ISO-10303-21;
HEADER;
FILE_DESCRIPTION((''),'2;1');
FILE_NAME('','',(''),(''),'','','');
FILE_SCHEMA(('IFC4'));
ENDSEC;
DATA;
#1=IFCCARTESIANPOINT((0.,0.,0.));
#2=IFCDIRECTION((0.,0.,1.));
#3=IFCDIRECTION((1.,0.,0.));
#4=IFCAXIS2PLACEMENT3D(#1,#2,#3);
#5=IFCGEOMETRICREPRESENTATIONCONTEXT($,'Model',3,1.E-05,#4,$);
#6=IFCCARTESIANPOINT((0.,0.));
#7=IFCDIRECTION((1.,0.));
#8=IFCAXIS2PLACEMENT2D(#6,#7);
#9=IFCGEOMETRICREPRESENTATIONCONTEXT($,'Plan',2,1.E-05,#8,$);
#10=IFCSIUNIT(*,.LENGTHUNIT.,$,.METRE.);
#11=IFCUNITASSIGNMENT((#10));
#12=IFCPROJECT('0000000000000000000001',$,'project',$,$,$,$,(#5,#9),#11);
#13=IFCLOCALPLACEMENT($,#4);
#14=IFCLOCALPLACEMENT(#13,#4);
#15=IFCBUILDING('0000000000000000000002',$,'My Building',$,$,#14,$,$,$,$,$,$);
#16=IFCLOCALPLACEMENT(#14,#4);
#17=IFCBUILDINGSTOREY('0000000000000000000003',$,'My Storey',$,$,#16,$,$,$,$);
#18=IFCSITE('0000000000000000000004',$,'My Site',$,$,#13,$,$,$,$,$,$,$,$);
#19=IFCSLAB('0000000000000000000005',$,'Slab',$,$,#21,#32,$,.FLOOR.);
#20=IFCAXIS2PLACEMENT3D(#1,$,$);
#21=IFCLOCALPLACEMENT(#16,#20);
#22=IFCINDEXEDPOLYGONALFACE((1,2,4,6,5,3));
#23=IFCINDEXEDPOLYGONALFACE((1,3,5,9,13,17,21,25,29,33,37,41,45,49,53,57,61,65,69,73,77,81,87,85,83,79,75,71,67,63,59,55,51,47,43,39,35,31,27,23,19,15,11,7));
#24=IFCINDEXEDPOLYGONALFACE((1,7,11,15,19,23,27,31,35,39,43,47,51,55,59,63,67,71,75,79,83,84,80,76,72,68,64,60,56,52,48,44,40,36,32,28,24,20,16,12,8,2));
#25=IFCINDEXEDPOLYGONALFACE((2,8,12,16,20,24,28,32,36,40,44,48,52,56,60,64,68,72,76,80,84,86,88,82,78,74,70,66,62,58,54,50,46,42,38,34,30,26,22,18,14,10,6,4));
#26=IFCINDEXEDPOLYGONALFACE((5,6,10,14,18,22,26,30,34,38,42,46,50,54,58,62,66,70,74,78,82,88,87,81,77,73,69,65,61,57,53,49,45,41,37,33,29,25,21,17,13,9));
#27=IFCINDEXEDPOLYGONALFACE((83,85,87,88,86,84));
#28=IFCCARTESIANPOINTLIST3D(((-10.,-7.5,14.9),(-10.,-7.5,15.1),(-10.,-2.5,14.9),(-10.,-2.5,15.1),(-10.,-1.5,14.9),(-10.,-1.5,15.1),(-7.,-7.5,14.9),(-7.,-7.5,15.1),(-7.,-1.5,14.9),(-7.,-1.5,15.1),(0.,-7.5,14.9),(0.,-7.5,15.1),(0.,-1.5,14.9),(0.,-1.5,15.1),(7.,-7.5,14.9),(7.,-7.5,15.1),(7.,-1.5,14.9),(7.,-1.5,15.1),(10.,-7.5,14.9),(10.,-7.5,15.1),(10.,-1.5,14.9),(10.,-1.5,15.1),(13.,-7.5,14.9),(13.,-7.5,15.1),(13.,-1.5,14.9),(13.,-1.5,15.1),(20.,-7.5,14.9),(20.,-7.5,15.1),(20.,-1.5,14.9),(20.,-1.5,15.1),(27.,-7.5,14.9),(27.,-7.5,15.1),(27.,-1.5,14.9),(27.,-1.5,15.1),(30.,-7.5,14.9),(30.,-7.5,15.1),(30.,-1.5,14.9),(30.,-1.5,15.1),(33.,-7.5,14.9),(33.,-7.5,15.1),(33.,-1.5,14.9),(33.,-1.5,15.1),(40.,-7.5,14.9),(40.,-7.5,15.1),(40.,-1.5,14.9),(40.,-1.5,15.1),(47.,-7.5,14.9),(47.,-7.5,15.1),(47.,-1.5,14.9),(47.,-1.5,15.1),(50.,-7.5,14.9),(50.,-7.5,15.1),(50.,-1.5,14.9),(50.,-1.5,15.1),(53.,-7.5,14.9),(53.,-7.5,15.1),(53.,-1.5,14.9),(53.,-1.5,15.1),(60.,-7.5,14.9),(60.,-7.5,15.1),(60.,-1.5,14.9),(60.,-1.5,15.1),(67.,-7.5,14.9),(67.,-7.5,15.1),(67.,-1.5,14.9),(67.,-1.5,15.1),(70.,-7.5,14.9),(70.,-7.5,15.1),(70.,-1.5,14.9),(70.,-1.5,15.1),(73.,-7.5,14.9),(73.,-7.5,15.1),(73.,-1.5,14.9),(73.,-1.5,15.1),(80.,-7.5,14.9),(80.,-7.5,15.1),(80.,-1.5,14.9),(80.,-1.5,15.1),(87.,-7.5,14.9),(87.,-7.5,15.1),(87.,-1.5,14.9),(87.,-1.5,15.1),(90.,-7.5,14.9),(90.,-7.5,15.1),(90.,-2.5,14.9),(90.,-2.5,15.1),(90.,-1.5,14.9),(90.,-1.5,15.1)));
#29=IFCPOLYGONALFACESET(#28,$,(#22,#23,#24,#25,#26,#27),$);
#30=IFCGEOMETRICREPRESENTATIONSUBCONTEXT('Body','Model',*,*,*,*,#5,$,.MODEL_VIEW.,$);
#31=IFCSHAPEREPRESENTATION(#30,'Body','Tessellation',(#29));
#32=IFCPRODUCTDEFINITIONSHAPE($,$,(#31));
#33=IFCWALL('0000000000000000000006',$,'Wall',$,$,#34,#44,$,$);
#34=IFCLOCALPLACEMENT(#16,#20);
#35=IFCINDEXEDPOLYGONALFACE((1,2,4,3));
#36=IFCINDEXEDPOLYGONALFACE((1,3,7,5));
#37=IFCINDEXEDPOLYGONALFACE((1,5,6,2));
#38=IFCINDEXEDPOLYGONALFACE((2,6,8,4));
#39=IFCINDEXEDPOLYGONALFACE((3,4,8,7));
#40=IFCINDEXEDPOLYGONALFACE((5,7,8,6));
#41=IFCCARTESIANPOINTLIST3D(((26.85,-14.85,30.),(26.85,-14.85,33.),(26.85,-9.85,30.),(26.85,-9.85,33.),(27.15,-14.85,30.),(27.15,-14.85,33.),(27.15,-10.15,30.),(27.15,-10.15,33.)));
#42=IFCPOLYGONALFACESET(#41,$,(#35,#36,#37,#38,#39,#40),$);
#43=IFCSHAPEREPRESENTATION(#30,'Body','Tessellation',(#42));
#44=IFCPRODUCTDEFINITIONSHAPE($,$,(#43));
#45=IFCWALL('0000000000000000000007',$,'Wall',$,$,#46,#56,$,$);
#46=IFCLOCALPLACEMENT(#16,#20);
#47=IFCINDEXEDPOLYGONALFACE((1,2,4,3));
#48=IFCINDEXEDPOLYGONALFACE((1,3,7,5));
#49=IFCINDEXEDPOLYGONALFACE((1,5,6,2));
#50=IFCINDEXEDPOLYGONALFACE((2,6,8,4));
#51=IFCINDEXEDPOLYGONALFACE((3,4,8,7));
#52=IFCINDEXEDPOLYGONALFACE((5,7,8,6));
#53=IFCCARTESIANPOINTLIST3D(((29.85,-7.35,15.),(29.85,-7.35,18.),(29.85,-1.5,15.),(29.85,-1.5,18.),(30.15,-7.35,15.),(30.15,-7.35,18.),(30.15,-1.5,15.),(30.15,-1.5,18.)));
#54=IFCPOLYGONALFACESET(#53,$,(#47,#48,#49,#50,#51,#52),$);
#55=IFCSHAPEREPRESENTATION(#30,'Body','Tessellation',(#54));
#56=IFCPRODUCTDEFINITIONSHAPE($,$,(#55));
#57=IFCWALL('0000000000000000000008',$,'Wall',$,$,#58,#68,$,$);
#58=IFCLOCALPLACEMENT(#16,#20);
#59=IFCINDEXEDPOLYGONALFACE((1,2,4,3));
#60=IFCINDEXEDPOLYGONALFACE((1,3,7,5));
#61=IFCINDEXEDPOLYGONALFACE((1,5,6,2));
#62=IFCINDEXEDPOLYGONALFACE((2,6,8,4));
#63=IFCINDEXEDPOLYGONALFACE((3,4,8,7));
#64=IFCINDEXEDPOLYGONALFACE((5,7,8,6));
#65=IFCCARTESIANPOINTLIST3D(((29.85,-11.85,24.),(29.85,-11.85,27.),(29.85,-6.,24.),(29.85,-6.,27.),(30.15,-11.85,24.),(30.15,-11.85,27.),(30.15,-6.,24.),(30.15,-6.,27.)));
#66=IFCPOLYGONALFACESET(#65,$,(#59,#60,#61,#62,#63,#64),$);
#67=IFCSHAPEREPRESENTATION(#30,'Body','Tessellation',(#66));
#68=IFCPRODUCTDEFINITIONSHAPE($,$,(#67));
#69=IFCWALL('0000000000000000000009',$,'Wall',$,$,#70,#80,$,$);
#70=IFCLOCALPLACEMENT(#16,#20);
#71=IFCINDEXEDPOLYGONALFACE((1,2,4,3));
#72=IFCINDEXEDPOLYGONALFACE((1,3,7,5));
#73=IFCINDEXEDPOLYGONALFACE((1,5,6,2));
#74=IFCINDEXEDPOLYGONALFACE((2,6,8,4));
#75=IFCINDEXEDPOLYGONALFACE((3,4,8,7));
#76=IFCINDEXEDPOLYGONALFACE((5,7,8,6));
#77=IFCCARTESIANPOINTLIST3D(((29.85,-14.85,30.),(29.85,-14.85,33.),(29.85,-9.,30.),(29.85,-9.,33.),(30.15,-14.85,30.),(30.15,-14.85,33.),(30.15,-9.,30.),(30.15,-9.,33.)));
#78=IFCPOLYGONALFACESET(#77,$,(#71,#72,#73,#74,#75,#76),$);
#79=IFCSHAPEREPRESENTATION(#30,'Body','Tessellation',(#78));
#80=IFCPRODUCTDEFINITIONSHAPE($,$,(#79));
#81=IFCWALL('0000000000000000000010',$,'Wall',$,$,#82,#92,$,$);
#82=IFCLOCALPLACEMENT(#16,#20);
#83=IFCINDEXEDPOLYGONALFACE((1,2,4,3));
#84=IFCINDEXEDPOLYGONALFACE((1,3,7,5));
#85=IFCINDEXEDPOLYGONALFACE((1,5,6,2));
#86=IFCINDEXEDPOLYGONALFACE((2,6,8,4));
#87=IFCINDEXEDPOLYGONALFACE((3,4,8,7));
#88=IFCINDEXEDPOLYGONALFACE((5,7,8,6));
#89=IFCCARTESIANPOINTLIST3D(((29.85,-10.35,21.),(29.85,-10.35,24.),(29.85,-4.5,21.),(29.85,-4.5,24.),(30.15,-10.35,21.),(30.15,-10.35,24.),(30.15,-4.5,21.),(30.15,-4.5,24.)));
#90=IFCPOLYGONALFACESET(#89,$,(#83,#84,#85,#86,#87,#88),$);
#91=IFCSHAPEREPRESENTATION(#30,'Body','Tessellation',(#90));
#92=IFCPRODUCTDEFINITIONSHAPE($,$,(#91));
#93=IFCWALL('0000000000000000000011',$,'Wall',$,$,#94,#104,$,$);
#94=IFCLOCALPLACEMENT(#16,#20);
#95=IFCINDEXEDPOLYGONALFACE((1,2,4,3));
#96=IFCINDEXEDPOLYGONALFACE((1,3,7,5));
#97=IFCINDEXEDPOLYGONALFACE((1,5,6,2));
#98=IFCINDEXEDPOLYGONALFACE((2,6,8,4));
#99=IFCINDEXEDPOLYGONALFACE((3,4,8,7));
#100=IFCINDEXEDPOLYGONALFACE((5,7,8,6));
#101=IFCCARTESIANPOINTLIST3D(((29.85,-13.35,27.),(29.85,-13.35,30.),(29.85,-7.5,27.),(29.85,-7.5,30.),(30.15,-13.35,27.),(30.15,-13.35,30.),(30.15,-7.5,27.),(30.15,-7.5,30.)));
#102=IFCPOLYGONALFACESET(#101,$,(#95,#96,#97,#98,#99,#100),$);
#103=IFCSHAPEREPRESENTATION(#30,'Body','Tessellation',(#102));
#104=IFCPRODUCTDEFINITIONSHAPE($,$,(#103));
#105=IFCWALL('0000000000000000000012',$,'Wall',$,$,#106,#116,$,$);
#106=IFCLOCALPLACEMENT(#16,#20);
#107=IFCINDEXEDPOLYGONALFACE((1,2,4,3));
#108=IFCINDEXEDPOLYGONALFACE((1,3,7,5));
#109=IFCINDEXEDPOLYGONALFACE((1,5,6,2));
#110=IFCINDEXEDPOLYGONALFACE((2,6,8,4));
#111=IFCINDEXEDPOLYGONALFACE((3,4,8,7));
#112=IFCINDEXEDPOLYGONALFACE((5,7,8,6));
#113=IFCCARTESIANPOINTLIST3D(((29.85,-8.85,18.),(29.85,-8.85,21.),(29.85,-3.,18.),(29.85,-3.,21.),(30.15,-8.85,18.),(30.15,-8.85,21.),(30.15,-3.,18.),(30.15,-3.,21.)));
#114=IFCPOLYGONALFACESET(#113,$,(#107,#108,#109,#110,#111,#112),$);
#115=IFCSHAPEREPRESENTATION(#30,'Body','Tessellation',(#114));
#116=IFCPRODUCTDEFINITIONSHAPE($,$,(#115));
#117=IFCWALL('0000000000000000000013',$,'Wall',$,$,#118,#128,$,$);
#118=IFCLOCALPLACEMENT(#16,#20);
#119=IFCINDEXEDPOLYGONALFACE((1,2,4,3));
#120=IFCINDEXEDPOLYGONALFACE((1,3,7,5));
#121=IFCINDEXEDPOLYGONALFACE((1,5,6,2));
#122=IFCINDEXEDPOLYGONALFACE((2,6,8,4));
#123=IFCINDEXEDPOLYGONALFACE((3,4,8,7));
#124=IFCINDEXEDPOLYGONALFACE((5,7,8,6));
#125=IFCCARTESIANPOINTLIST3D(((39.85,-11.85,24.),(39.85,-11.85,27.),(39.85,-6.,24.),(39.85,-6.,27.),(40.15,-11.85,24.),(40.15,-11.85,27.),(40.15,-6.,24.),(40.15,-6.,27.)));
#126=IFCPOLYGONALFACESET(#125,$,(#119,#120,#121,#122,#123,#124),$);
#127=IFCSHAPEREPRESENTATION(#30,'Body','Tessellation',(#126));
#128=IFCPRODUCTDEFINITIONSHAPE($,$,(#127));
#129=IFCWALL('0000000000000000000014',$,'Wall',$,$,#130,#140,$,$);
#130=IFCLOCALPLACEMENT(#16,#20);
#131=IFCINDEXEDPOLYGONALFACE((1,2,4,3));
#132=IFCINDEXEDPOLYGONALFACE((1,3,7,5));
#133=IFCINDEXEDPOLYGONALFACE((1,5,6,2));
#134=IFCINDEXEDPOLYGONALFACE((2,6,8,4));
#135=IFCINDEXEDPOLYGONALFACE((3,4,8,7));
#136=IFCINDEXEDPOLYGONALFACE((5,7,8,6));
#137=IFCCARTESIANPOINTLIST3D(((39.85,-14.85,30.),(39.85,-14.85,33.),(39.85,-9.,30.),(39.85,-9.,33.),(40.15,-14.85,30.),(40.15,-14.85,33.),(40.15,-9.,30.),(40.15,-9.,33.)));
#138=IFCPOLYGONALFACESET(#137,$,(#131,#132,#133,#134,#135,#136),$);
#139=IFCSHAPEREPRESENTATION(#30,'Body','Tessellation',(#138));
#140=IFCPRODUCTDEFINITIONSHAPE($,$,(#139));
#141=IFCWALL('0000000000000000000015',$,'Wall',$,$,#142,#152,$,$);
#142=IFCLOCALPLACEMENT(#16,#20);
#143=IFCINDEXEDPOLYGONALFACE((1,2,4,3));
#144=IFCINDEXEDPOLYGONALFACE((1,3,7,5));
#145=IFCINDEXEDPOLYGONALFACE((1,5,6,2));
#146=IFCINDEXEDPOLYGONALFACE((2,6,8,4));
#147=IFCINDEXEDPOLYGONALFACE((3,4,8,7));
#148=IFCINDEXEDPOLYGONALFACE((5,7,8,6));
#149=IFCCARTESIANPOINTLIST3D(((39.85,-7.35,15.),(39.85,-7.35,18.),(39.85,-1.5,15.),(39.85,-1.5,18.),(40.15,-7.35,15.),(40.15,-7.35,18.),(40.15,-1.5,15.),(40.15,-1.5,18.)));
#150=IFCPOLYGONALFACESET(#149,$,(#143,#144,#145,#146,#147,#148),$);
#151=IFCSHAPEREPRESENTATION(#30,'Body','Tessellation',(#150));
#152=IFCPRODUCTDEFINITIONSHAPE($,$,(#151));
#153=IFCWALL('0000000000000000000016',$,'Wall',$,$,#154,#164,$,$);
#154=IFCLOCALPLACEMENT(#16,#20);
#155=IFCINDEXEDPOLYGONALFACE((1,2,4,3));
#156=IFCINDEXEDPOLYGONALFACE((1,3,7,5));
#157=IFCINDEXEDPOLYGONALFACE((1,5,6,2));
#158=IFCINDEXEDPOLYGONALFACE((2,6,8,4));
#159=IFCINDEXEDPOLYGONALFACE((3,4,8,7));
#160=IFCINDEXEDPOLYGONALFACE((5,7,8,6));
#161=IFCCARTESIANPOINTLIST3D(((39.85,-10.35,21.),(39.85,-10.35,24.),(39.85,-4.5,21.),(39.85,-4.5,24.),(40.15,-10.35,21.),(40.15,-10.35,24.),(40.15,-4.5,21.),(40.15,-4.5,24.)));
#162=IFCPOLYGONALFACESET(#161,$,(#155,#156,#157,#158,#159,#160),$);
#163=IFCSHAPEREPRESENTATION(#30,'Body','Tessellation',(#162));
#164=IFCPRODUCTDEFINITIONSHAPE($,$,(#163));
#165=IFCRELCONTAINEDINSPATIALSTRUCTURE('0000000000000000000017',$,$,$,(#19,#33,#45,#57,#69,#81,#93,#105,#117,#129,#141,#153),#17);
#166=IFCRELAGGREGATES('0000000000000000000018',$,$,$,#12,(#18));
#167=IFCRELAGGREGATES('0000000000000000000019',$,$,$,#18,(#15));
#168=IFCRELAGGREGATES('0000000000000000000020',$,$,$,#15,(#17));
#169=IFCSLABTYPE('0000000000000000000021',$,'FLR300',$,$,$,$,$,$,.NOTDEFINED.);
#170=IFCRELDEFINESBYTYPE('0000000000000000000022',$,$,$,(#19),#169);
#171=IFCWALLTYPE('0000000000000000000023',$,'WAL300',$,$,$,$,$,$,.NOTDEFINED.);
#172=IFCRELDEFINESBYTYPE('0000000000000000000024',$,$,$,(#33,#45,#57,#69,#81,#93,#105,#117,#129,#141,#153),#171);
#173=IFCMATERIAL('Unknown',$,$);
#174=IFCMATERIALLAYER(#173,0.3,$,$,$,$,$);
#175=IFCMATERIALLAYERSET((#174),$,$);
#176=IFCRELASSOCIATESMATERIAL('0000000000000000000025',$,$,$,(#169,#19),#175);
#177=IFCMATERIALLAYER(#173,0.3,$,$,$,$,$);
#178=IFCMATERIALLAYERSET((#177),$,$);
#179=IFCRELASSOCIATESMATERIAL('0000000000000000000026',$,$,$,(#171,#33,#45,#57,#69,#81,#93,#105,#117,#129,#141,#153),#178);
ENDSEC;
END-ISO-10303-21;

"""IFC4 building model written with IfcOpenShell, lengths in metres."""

from ifc_helpers import new_model, si_unit, frame, origin, origin_with_axes, origin_2d_with_axis, place, context, subcontext, project, spatial, polyline, line, indexed_curve, outline, extrude, material, layer, layer_set, layer_usage, type_object, element, save


model = new_model("IFC4")

# Units and contexts
model_context = context("Model", 3, precision=1e-05, world=origin_with_axes())
plan_context = context("Plan", 2, precision=1e-05, world=origin_2d_with_axis())
body_context = subcontext(model_context, "Body", "Model", "MODEL_VIEW")
ifc_project = project(units=[si_unit("LENGTHUNIT", "METRE")], contexts=[model_context, plan_context])

# Site, building, storey
site_placement = place(None, origin_with_axes())
site = spatial("IfcSite", under=ifc_project, at=site_placement, Name="My Site")
building_placement = place(site_placement, origin_with_axes())
building = spatial("IfcBuilding", under=site, at=building_placement, Name="My Building")
storey_placement = place(building_placement, origin_with_axes())
storey = spatial("IfcBuildingStorey", under=building, at=storey_placement, Name="My Storey")

# Slab
ifc_material = material(Name="Unknown")
ifc_layer_1 = layer(ifc_material, 0.3)
ifc_layer_set_1 = layer_set([ifc_layer_1])
ifc_layer_usage_1 = layer_usage(ifc_layer_set_1, "AXIS3", "POSITIVE", 0.0)
slab_type = type_object("IfcSlabType", Name="FLR300", PredefinedType="NOTDEFINED", material=ifc_layer_set_1)
slab_placement = place(storey_placement, frame((40.0, -4.4091, 14.9), z_axis=(0.0, 0.0, 1.0), x_axis=(1.0, 0.0, 0.0)))
element("IfcSlab", 1, at=slab_placement, inside=storey, type_object=slab_type, material=ifc_layer_usage_1, Name="Slab", PredefinedType="FLOOR", context=body_context, shape_type="SweptSolid", body=[
    extrude(outline(polyline([(-47.0, 2.9091), (-50.0, 2.9091), (-50.0, 1.9091), (-50.0, -3.0909), (-47.0, -3.0909), (-40.0, -3.0909), (-33.0, -3.0909), (-30.0, -3.0909), (-27.0, -3.0909), (-20.0, -3.0909), (-13.0, -3.0909), (-10.0, -3.0909), (-7.0, -3.0909), (0.0, -3.0909), (7.0, -3.0909), (10.0, -3.0909), (13.0, -3.0909), (20.0, -3.0909), (27.0, -3.0909), (30.0, -3.0909), (33.0, -3.0909), (40.0, -3.0909), (47.0, -3.0909), (50.0, -3.0909), (50.0, 1.9091), (50.0, 2.9091), (47.0, 2.9091), (40.0, 2.9091), (33.0, 2.9091), (30.0, 2.9091), (27.0, 2.9091), (20.0, 2.9091), (13.0, 2.9091), (10.0, 2.9091), (7.0, 2.9091), (0.0, 2.9091), (-7.0, 2.9091), (-10.0, 2.9091), (-13.0, 2.9091), (-20.0, 2.9091), (-27.0, 2.9091), (-30.0, 2.9091), (-33.0, 2.9091), (-40.0, 2.9091), (-47.0, 2.9091)])), origin(), (0.0, 0.0, 1.0), 0.2),
])

# Walls
ifc_layer_2 = layer(ifc_material, 0.3)
ifc_layer_set_2 = layer_set([ifc_layer_2])
ifc_layer_usage_2 = layer_usage(ifc_layer_set_2, "AXIS2", "POSITIVE", -0.15)
wall_type = type_object("IfcWallType", Name="WAL300", PredefinedType="NOTDEFINED", material=ifc_layer_set_2)
wall_1_placement = place(storey_placement, frame((27.0, -10.0, 30.0), z_axis=(0.0, 0.0, 1.0), x_axis=(0.0, -1.0, 0.0)))
element("IfcWall", 2, at=wall_1_placement, inside=storey, type_object=wall_type, material=ifc_layer_usage_2, Name="Wall", context=body_context, shape_type="SweptSolid", body=[
    extrude(outline(indexed_curve([(-0.15, -0.15), (0.15, 0.15), (4.85, 0.15), (4.85, -0.15)], segments=[line(1, 2, 3, 4, 1)])), origin_with_axes(), (0.0, 0.0, 1.0), 3.0),
])
ifc_layer_usage_3 = layer_usage(ifc_layer_set_2, "AXIS2", "POSITIVE", -0.15)
wall_2_placement = place(storey_placement, frame((30.0, -1.5, 15.0), z_axis=(0.0, 0.0, 1.0), x_axis=(0.0, -1.0, 0.0)))
element("IfcWall", 3, at=wall_2_placement, inside=storey, type_object=wall_type, material=ifc_layer_usage_3, Name="Wall", context=body_context, shape_type="SweptSolid", body=[
    extrude(outline(indexed_curve([(0.0, -0.15), (0.0, 0.15), (5.85, 0.15), (5.85, -0.15)], segments=[line(1, 2, 3, 4, 1)])), origin_with_axes(), (0.0, 0.0, 1.0), 3.0),
])
ifc_layer_usage_4 = layer_usage(ifc_layer_set_2, "AXIS2", "POSITIVE", -0.15)
wall_3_placement = place(storey_placement, frame((30.0, -6.0, 24.0), z_axis=(0.0, 0.0, 1.0), x_axis=(0.0, -1.0, 0.0)))
element("IfcWall", 4, at=wall_3_placement, inside=storey, type_object=wall_type, material=ifc_layer_usage_4, Name="Wall", context=body_context, shape_type="SweptSolid", body=[
    extrude(outline(indexed_curve([(0.0, -0.15), (0.0, 0.15), (5.85, 0.15), (5.85, -0.15)], segments=[line(1, 2, 3, 4, 1)])), origin_with_axes(), (0.0, 0.0, 1.0), 3.0),
])
ifc_layer_usage_5 = layer_usage(ifc_layer_set_2, "AXIS2", "POSITIVE", -0.15)
wall_4_placement = place(storey_placement, frame((30.0, -9.0, 30.0), z_axis=(0.0, 0.0, 1.0), x_axis=(0.0, -1.0, 0.0)))
element("IfcWall", 5, at=wall_4_placement, inside=storey, type_object=wall_type, material=ifc_layer_usage_5, Name="Wall", context=body_context, shape_type="SweptSolid", body=[
    extrude(outline(indexed_curve([(0.0, -0.15), (0.0, 0.15), (5.85, 0.15), (5.85, -0.15)], segments=[line(1, 2, 3, 4, 1)])), origin_with_axes(), (0.0, 0.0, 1.0), 3.0),
])
ifc_layer_usage_6 = layer_usage(ifc_layer_set_2, "AXIS2", "POSITIVE", -0.15)
wall_5_placement = place(storey_placement, frame((30.0, -4.5, 21.0), z_axis=(0.0, 0.0, 1.0), x_axis=(0.0, -1.0, 0.0)))
element("IfcWall", 6, at=wall_5_placement, inside=storey, type_object=wall_type, material=ifc_layer_usage_6, Name="Wall", context=body_context, shape_type="SweptSolid", body=[
    extrude(outline(indexed_curve([(0.0, -0.15), (0.0, 0.15), (5.85, 0.15), (5.85, -0.15)], segments=[line(1, 2, 3, 4, 1)])), origin_with_axes(), (0.0, 0.0, 1.0), 3.0),
])
ifc_layer_usage_7 = layer_usage(ifc_layer_set_2, "AXIS2", "POSITIVE", -0.15)
wall_6_placement = place(storey_placement, frame((30.0, -7.5, 27.0), z_axis=(0.0, 0.0, 1.0), x_axis=(0.0, -1.0, 0.0)))
element("IfcWall", 7, at=wall_6_placement, inside=storey, type_object=wall_type, material=ifc_layer_usage_7, Name="Wall", context=body_context, shape_type="SweptSolid", body=[
    extrude(outline(indexed_curve([(0.0, -0.15), (0.0, 0.15), (5.85, 0.15), (5.85, -0.15)], segments=[line(1, 2, 3, 4, 1)])), origin_with_axes(), (0.0, 0.0, 1.0), 3.0),
])
ifc_layer_usage_8 = layer_usage(ifc_layer_set_2, "AXIS2", "POSITIVE", -0.15)
wall_7_placement = place(storey_placement, frame((30.0, -3.0, 18.0), z_axis=(0.0, 0.0, 1.0), x_axis=(0.0, -1.0, 0.0)))
element("IfcWall", 8, at=wall_7_placement, inside=storey, type_object=wall_type, material=ifc_layer_usage_8, Name="Wall", context=body_context, shape_type="SweptSolid", body=[
    extrude(outline(indexed_curve([(0.0, -0.15), (0.0, 0.15), (5.85, 0.15), (5.85, -0.15)], segments=[line(1, 2, 3, 4, 1)])), origin_with_axes(), (0.0, 0.0, 1.0), 3.0),
])
ifc_layer_usage_9 = layer_usage(ifc_layer_set_2, "AXIS2", "POSITIVE", -0.15)
wall_8_placement = place(storey_placement, frame((40.0, -12.0, 24.0), z_axis=(0.0, 0.0, 1.0), x_axis=(0.0, 1.0, 0.0)))
element("IfcWall", 9, at=wall_8_placement, inside=storey, type_object=wall_type, material=ifc_layer_usage_9, Name="Wall", context=body_context, shape_type="SweptSolid", body=[
    extrude(outline(indexed_curve([(0.15, -0.15), (0.15, 0.15), (6.0, 0.15), (6.0, -0.15)], segments=[line(1, 2, 3, 4, 1)])), origin_with_axes(), (0.0, 0.0, 1.0), 3.0),
])
ifc_layer_usage_10 = layer_usage(ifc_layer_set_2, "AXIS2", "POSITIVE", -0.15)
wall_9_placement = place(storey_placement, frame((40.0, -15.0, 30.0), z_axis=(0.0, 0.0, 1.0), x_axis=(0.0, 1.0, 0.0)))
element("IfcWall", 10, at=wall_9_placement, inside=storey, type_object=wall_type, material=ifc_layer_usage_10, Name="Wall", context=body_context, shape_type="SweptSolid", body=[
    extrude(outline(indexed_curve([(0.15, -0.15), (0.15, 0.15), (6.0, 0.15), (6.0, -0.15)], segments=[line(1, 2, 3, 4, 1)])), origin_with_axes(), (0.0, 0.0, 1.0), 3.0),
])
ifc_layer_usage_11 = layer_usage(ifc_layer_set_2, "AXIS2", "POSITIVE", -0.15)
wall_10_placement = place(storey_placement, frame((40.0, -7.5, 15.0), z_axis=(0.0, 0.0, 1.0), x_axis=(0.0, 1.0, 0.0)))
element("IfcWall", 11, at=wall_10_placement, inside=storey, type_object=wall_type, material=ifc_layer_usage_11, Name="Wall", context=body_context, shape_type="SweptSolid", body=[
    extrude(outline(indexed_curve([(0.15, -0.15), (0.15, 0.15), (6.0, 0.15), (6.0, -0.15)], segments=[line(1, 2, 3, 4, 1)])), origin_with_axes(), (0.0, 0.0, 1.0), 3.0),
])
ifc_layer_usage_12 = layer_usage(ifc_layer_set_2, "AXIS2", "POSITIVE", -0.15)
wall_11_placement = place(storey_placement, frame((40.0, -10.5, 21.0), z_axis=(0.0, 0.0, 1.0), x_axis=(0.0, 1.0, 0.0)))
element("IfcWall", 12, at=wall_11_placement, inside=storey, type_object=wall_type, material=ifc_layer_usage_12, Name="Wall", context=body_context, shape_type="SweptSolid", body=[
    extrude(outline(indexed_curve([(0.15, -0.15), (0.15, 0.15), (6.0, 0.15), (6.0, -0.15)], segments=[line(1, 2, 3, 4, 1)])), origin_with_axes(), (0.0, 0.0, 1.0), 3.0),
])

save(model, "model.ifc")
